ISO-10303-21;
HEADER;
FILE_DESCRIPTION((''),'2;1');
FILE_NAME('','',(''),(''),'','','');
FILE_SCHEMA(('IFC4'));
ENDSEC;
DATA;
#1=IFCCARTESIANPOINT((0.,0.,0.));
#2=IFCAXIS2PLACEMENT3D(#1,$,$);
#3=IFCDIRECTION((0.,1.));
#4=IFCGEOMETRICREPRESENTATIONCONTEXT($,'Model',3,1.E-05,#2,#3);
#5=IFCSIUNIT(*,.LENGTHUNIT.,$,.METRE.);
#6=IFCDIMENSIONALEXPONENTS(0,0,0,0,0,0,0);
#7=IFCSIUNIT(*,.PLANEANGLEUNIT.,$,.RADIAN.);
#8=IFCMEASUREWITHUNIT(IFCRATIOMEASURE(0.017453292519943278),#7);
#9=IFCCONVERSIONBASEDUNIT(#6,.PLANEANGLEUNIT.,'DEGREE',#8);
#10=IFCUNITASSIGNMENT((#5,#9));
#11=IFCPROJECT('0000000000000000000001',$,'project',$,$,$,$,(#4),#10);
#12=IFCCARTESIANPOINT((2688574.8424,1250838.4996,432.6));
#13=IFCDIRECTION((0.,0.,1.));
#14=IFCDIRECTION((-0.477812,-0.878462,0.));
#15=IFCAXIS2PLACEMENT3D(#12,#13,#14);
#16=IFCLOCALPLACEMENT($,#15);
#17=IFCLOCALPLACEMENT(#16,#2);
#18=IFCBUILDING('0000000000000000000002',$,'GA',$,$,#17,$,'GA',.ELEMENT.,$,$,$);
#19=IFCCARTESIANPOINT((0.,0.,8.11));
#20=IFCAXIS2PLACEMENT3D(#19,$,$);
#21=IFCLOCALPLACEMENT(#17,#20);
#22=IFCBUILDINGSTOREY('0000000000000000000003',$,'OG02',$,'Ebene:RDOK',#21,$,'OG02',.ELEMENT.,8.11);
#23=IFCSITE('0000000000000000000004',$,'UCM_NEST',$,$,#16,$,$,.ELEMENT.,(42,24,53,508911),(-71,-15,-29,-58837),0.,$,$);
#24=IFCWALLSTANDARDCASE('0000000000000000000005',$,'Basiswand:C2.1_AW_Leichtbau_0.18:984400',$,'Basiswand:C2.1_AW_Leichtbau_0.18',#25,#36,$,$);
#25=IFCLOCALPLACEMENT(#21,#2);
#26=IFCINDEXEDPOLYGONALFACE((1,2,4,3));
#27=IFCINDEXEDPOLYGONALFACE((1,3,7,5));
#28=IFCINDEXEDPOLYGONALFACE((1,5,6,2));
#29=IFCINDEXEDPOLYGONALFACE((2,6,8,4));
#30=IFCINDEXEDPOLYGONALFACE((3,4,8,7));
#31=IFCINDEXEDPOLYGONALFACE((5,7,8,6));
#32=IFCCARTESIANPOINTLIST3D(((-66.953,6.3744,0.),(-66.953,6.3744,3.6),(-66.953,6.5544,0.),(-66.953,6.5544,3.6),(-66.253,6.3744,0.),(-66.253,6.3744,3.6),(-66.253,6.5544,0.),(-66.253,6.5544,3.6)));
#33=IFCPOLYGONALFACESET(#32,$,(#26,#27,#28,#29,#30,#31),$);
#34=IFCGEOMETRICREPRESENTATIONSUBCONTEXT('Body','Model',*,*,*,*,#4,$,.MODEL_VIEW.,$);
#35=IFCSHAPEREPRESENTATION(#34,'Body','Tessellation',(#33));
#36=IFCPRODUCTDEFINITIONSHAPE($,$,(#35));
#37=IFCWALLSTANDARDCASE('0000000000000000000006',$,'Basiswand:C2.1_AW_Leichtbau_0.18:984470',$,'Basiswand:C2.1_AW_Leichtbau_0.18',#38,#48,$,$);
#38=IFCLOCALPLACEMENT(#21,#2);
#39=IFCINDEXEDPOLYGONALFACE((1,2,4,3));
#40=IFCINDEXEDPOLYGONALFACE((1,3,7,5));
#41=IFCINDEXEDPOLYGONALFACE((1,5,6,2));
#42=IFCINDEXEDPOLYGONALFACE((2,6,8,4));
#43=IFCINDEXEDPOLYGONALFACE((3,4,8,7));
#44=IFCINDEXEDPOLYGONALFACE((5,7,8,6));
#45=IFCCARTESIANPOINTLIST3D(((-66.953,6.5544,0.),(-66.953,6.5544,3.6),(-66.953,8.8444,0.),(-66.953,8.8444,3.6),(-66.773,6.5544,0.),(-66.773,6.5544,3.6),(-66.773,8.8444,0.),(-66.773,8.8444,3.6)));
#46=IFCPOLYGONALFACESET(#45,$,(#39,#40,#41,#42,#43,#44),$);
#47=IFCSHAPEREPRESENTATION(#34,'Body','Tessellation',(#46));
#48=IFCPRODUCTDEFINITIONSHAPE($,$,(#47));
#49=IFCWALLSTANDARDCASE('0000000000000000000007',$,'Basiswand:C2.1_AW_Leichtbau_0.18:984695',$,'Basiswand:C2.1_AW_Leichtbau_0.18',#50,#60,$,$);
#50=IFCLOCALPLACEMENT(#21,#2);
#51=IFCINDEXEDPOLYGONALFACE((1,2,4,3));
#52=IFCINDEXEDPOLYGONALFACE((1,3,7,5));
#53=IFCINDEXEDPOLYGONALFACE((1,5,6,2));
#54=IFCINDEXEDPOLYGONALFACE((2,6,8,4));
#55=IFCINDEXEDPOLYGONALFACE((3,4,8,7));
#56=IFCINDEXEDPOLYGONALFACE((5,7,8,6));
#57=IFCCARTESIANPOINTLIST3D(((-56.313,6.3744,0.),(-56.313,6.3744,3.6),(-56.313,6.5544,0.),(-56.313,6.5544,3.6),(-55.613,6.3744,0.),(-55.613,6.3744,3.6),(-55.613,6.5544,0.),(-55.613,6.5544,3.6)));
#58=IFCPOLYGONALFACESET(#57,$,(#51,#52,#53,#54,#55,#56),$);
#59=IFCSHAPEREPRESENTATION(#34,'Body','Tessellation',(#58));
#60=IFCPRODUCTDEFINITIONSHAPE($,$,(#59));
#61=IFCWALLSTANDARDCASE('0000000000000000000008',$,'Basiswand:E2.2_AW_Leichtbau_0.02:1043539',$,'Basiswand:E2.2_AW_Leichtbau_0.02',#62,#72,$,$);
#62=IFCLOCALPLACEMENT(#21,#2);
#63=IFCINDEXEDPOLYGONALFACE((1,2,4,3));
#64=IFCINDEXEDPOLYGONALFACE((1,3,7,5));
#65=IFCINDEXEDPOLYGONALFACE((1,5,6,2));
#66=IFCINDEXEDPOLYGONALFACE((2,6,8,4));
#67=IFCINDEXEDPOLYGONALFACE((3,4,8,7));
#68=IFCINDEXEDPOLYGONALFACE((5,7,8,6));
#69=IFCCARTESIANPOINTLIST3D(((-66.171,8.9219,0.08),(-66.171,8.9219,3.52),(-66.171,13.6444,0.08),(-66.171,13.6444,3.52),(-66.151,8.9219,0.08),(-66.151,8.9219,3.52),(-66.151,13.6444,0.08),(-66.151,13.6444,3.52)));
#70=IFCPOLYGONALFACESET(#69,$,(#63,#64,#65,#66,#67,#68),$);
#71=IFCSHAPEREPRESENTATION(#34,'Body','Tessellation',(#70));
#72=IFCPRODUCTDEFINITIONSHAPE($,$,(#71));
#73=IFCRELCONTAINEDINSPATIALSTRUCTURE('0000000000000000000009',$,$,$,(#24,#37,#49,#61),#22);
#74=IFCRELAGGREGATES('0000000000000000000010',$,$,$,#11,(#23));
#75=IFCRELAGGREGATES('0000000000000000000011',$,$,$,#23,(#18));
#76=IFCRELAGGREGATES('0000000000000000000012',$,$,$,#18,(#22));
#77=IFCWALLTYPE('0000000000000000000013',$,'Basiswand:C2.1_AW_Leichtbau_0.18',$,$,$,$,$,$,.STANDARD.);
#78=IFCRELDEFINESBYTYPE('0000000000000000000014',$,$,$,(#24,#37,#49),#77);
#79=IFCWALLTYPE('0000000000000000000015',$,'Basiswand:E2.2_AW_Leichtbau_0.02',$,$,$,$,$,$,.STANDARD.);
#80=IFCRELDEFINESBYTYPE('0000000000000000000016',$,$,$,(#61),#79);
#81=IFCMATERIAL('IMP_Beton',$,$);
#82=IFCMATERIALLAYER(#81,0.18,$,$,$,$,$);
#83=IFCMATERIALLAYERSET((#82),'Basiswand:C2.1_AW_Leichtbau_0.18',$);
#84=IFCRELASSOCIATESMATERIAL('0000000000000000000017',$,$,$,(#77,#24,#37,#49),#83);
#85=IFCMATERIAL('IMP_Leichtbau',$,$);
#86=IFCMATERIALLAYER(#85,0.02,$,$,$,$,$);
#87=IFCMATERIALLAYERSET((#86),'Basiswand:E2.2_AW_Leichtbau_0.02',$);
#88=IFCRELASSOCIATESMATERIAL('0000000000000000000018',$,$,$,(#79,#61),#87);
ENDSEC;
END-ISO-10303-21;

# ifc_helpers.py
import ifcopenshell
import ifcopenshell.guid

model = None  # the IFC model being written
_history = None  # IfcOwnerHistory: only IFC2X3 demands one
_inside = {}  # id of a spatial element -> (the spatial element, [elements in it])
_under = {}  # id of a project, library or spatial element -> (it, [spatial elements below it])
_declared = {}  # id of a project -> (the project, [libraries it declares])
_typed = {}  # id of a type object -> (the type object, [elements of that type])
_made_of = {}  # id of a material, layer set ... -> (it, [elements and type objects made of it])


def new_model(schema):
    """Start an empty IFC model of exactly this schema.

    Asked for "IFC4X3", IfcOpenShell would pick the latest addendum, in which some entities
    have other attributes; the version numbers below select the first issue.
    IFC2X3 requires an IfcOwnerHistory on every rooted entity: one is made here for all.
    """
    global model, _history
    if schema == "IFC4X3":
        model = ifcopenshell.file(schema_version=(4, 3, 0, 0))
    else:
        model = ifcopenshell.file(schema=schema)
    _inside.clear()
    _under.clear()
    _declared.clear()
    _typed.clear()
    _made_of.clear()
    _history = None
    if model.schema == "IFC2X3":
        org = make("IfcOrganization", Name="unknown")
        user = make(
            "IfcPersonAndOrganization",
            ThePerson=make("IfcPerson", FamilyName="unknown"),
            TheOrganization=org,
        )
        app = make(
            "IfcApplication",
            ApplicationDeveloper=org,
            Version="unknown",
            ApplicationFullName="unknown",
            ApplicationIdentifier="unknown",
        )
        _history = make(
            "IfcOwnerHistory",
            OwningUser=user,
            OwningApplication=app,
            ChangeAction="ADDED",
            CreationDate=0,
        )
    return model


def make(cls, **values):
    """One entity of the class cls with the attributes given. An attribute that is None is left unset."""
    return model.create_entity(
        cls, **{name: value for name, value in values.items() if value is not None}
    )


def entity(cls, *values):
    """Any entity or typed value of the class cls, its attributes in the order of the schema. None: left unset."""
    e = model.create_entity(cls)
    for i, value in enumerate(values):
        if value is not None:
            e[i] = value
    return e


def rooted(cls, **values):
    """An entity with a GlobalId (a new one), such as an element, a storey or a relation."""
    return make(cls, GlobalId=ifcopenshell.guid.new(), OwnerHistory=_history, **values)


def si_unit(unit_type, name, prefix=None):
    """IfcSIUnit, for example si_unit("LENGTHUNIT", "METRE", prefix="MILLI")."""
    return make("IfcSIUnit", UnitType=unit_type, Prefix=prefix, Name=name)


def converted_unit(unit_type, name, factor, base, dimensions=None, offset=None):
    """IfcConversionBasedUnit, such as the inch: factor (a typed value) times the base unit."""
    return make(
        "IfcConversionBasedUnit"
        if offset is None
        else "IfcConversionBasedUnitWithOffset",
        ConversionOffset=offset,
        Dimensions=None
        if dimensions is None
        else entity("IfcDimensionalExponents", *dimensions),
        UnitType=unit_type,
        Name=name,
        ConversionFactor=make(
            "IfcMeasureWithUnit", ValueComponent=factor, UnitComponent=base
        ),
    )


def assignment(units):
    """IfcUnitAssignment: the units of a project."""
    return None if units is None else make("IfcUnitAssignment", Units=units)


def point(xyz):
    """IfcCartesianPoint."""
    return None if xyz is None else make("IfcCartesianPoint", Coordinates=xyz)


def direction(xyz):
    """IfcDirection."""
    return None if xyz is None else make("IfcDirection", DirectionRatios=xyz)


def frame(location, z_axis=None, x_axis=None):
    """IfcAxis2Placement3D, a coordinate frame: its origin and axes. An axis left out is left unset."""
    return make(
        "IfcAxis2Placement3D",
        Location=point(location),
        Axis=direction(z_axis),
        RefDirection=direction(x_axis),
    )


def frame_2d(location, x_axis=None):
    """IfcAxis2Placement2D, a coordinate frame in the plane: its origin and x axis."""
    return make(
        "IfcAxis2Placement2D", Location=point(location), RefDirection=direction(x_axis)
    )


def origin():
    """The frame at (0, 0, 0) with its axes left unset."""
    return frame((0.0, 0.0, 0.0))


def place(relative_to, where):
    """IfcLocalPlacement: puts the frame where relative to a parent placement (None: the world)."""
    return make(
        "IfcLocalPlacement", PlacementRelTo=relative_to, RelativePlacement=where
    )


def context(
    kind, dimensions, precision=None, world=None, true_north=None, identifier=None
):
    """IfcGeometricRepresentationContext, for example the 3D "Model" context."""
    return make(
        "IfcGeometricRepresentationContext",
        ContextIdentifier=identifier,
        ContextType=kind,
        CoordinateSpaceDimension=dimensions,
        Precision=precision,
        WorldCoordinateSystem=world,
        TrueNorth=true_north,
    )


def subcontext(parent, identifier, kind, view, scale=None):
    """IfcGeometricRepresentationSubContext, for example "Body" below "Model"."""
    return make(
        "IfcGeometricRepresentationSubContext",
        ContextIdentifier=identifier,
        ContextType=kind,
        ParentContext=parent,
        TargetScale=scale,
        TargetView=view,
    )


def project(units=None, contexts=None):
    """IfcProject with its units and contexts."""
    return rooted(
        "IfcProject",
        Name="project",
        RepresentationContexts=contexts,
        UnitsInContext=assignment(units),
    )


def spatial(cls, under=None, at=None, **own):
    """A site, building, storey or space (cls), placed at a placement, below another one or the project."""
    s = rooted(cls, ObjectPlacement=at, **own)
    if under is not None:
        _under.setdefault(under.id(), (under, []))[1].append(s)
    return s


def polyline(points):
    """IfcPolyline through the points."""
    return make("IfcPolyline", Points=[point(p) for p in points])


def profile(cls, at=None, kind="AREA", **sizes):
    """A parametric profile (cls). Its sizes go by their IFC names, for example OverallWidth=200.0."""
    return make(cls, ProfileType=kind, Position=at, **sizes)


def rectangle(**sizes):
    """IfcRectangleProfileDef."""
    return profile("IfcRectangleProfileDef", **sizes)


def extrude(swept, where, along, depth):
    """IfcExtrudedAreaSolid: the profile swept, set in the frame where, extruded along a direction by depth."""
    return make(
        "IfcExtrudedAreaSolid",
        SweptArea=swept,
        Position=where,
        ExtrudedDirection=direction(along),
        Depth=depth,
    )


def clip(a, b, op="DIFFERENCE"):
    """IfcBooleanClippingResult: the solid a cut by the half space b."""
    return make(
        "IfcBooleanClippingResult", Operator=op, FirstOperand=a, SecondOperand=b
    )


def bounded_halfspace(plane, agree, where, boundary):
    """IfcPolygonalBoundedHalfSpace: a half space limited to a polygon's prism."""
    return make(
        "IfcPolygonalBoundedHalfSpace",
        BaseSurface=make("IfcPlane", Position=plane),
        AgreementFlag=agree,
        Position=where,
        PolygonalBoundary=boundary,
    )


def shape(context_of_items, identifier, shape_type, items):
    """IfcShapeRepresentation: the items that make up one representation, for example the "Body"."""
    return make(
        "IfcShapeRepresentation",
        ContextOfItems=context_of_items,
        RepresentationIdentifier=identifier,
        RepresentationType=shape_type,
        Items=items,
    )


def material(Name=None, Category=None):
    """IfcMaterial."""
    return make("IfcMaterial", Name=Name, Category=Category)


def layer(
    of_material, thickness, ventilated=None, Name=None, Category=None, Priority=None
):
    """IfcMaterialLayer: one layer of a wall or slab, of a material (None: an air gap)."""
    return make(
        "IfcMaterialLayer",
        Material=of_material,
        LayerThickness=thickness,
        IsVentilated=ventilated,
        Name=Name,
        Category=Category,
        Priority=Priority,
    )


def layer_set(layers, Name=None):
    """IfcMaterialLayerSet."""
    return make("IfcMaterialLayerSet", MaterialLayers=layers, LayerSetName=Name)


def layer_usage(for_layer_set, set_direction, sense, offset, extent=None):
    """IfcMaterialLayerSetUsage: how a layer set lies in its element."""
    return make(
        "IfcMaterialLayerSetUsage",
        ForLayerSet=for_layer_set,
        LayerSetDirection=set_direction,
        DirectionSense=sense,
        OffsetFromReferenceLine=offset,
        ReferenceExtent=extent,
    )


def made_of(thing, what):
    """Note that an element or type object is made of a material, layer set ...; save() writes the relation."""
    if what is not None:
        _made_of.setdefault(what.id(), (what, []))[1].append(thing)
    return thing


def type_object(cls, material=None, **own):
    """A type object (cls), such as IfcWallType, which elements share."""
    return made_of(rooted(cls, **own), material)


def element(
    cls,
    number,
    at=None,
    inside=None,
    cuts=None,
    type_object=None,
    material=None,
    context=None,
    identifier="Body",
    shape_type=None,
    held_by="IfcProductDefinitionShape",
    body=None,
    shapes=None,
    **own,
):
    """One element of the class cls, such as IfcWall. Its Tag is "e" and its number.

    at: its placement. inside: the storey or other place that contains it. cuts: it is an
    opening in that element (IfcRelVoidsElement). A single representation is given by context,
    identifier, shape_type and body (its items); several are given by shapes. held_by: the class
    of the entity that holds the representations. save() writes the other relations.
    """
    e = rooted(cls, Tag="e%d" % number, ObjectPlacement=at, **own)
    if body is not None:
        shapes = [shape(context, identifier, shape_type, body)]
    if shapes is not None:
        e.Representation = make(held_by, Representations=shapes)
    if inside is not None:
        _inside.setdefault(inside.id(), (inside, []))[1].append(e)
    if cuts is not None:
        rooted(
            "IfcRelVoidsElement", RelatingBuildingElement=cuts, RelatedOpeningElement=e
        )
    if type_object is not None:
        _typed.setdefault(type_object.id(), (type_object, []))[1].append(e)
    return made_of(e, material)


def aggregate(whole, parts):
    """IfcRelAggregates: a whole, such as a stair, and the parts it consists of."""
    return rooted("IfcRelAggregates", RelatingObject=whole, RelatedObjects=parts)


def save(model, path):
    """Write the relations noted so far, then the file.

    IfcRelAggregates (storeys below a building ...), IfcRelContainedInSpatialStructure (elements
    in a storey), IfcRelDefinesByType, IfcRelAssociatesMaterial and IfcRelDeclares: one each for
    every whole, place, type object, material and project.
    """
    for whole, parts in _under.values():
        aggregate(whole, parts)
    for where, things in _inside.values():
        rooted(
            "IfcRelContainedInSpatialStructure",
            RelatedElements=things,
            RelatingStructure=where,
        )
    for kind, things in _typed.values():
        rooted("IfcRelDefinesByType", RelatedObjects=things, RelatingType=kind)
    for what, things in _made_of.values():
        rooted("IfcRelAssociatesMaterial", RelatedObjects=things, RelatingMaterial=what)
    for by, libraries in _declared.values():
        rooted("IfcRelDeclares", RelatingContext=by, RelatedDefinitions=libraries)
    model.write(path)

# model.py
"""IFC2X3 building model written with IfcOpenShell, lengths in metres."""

from ifc_helpers import new_model, entity, si_unit, converted_unit, direction, frame, frame_2d, origin, place, context, subcontext, project, spatial, polyline, rectangle, extrude, clip, bounded_halfspace, material, layer, layer_set, layer_usage, type_object, element, save


model = new_model("IFC2X3")

# Units and contexts
model_context = context("Model", 3, precision=1e-05, world=origin(), true_north=direction((0.0, 1.0)))
body_context = subcontext(model_context, "Body", "Model", "MODEL_VIEW")
ifc_project = project(units=[si_unit("LENGTHUNIT", "METRE"), converted_unit("PLANEANGLEUNIT", "DEGREE", entity("IfcRatioMeasure", 0.017453292519943278), si_unit("PLANEANGLEUNIT", "RADIAN"), dimensions=[0, 0, 0, 0, 0, 0, 0])], contexts=[model_context])

# Site, building, storey
site_placement = place(None, frame((2688574.8424, 1250838.4996, 432.6), z_axis=(0.0, 0.0, 1.0), x_axis=(-0.477812, -0.878462, 0.0)))
site = spatial("IfcSite", under=ifc_project, at=site_placement, Name="UCM_NEST", CompositionType="ELEMENT", RefLatitude=(42, 24, 53, 508911), RefLongitude=(-71, -15, -29, -58837), RefElevation=0.0)
building_placement = place(site_placement, origin())
building = spatial("IfcBuilding", under=site, at=building_placement, Name="GA", LongName="GA", CompositionType="ELEMENT")
storey_placement = place(building_placement, frame((0.0, 0.0, 8.11)))
storey = spatial("IfcBuildingStorey", under=building, at=storey_placement, Name="OG02", ObjectType="Ebene:RDOK", LongName="OG02", CompositionType="ELEMENT", Elevation=8.11)

# Walls
ifc_material_1 = material(Name="IMP_Leichtbau")
ifc_material_2 = material(Name="IMP_Beton")
ifc_layer_1 = layer(ifc_material_2, 0.18)
ifc_layer_set_1 = layer_set([ifc_layer_1], Name="Basiswand:C2.1_AW_Leichtbau_0.18")
ifc_layer_usage_1 = layer_usage(ifc_layer_set_1, "AXIS2", "NEGATIVE", 0.09)
wall_type_1 = type_object("IfcWallType", Name="Basiswand:C2.1_AW_Leichtbau_0.18", PredefinedType="STANDARD", material=ifc_layer_set_1)
wall_1_placement = place(storey_placement, frame((-66.253, 6.4644, 0.0), z_axis=(0.0, 0.0, 1.0), x_axis=(-1.0, 0.0, 0.0)))
element("IfcWallStandardCase", 1, at=wall_1_placement, inside=storey, type_object=wall_type_1, material=ifc_layer_usage_1, Name="Basiswand:C2.1_AW_Leichtbau_0.18:984400", ObjectType="Basiswand:C2.1_AW_Leichtbau_0.18", context=body_context, shape_type="SweptSolid", body=[
    extrude(rectangle(XDim=0.7, YDim=0.18, at=frame_2d((0.35, 0.0), x_axis=(-1.0, 0.0))), origin(), (0.0, 0.0, 1.0), 3.6),
])
wall_2_placement = place(storey_placement, frame((-66.863, 6.5544, 0.0), z_axis=(0.0, 0.0, 1.0), x_axis=(0.0, 1.0, 0.0)))
element("IfcWallStandardCase", 2, at=wall_2_placement, inside=storey, type_object=wall_type_1, material=ifc_layer_usage_1, Name="Basiswand:C2.1_AW_Leichtbau_0.18:984470", ObjectType="Basiswand:C2.1_AW_Leichtbau_0.18", context=body_context, shape_type="SweptSolid", body=[
    extrude(rectangle(XDim=2.29, YDim=0.18, at=frame_2d((1.145, 0.0), x_axis=(-1.0, 0.0))), origin(), (0.0, 0.0, 1.0), 3.6),
])
wall_3_placement = place(storey_placement, frame((-56.313, 6.4644, 0.0)))
element("IfcWallStandardCase", 3, at=wall_3_placement, inside=storey, type_object=wall_type_1, material=ifc_layer_usage_1, Name="Basiswand:C2.1_AW_Leichtbau_0.18:984695", ObjectType="Basiswand:C2.1_AW_Leichtbau_0.18", context=body_context, shape_type="SweptSolid", body=[
    extrude(rectangle(XDim=0.7, YDim=0.18, at=frame_2d((0.35, 0.0), x_axis=(-1.0, 0.0))), origin(), (0.0, 0.0, 1.0), 3.6),
])
ifc_layer_2 = layer(ifc_material_1, 0.02)
ifc_layer_set_2 = layer_set([ifc_layer_2], Name="Basiswand:E2.2_AW_Leichtbau_0.02")
ifc_layer_usage_2 = layer_usage(ifc_layer_set_2, "AXIS2", "NEGATIVE", 0.01)
wall_type_2 = type_object("IfcWallType", Name="Basiswand:E2.2_AW_Leichtbau_0.02", PredefinedType="STANDARD", material=ifc_layer_set_2)
wall_4_placement = place(storey_placement, frame((-66.161, 8.9219, 0.08), z_axis=(0.0, 0.0, 1.0), x_axis=(0.0, 1.0, 0.0)))
element("IfcWallStandardCase", 4, at=wall_4_placement, inside=storey, type_object=wall_type_2, material=ifc_layer_usage_2, Name="Basiswand:E2.2_AW_Leichtbau_0.02:1043539", ObjectType="Basiswand:E2.2_AW_Leichtbau_0.02", context=body_context, shape_type="Clipping", body=[
    clip(clip(extrude(rectangle(XDim=4.7226, YDim=0.02, at=frame_2d((2.3613, 0.0), x_axis=(-1.0, 0.0))), origin(), (0.0, 0.0, 1.0), 3.44), bounded_halfspace(frame((4.7226, -0.01, 0.0), z_axis=(0.0, 0.0, 1.0), x_axis=(0.0, 1.0, 0.0)), True, frame((4.7226, -0.01, 0.0), z_axis=(0.0, 0.0, 1.0), x_axis=(0.0, 1.0, 0.0)), polyline([(0.0, 0.0), (0.02, 0.0), (0.02, 4.7226), (0.0, 4.7226), (0.0, 0.0)]))), bounded_halfspace(frame((0.0, -0.01, 3.44), z_axis=(0.0, 0.0, -1.0), x_axis=(0.0, 1.0, 0.0)), True, frame((0.0, -0.01, 3.44), z_axis=(0.0, 0.0, -1.0), x_axis=(0.0, 1.0, 0.0)), polyline([(0.0, 0.0), (0.02, 0.0), (0.02, 4.7226), (0.0, 4.7226), (0.0, 0.0)]))),
])

save(model, "model.ifc")
